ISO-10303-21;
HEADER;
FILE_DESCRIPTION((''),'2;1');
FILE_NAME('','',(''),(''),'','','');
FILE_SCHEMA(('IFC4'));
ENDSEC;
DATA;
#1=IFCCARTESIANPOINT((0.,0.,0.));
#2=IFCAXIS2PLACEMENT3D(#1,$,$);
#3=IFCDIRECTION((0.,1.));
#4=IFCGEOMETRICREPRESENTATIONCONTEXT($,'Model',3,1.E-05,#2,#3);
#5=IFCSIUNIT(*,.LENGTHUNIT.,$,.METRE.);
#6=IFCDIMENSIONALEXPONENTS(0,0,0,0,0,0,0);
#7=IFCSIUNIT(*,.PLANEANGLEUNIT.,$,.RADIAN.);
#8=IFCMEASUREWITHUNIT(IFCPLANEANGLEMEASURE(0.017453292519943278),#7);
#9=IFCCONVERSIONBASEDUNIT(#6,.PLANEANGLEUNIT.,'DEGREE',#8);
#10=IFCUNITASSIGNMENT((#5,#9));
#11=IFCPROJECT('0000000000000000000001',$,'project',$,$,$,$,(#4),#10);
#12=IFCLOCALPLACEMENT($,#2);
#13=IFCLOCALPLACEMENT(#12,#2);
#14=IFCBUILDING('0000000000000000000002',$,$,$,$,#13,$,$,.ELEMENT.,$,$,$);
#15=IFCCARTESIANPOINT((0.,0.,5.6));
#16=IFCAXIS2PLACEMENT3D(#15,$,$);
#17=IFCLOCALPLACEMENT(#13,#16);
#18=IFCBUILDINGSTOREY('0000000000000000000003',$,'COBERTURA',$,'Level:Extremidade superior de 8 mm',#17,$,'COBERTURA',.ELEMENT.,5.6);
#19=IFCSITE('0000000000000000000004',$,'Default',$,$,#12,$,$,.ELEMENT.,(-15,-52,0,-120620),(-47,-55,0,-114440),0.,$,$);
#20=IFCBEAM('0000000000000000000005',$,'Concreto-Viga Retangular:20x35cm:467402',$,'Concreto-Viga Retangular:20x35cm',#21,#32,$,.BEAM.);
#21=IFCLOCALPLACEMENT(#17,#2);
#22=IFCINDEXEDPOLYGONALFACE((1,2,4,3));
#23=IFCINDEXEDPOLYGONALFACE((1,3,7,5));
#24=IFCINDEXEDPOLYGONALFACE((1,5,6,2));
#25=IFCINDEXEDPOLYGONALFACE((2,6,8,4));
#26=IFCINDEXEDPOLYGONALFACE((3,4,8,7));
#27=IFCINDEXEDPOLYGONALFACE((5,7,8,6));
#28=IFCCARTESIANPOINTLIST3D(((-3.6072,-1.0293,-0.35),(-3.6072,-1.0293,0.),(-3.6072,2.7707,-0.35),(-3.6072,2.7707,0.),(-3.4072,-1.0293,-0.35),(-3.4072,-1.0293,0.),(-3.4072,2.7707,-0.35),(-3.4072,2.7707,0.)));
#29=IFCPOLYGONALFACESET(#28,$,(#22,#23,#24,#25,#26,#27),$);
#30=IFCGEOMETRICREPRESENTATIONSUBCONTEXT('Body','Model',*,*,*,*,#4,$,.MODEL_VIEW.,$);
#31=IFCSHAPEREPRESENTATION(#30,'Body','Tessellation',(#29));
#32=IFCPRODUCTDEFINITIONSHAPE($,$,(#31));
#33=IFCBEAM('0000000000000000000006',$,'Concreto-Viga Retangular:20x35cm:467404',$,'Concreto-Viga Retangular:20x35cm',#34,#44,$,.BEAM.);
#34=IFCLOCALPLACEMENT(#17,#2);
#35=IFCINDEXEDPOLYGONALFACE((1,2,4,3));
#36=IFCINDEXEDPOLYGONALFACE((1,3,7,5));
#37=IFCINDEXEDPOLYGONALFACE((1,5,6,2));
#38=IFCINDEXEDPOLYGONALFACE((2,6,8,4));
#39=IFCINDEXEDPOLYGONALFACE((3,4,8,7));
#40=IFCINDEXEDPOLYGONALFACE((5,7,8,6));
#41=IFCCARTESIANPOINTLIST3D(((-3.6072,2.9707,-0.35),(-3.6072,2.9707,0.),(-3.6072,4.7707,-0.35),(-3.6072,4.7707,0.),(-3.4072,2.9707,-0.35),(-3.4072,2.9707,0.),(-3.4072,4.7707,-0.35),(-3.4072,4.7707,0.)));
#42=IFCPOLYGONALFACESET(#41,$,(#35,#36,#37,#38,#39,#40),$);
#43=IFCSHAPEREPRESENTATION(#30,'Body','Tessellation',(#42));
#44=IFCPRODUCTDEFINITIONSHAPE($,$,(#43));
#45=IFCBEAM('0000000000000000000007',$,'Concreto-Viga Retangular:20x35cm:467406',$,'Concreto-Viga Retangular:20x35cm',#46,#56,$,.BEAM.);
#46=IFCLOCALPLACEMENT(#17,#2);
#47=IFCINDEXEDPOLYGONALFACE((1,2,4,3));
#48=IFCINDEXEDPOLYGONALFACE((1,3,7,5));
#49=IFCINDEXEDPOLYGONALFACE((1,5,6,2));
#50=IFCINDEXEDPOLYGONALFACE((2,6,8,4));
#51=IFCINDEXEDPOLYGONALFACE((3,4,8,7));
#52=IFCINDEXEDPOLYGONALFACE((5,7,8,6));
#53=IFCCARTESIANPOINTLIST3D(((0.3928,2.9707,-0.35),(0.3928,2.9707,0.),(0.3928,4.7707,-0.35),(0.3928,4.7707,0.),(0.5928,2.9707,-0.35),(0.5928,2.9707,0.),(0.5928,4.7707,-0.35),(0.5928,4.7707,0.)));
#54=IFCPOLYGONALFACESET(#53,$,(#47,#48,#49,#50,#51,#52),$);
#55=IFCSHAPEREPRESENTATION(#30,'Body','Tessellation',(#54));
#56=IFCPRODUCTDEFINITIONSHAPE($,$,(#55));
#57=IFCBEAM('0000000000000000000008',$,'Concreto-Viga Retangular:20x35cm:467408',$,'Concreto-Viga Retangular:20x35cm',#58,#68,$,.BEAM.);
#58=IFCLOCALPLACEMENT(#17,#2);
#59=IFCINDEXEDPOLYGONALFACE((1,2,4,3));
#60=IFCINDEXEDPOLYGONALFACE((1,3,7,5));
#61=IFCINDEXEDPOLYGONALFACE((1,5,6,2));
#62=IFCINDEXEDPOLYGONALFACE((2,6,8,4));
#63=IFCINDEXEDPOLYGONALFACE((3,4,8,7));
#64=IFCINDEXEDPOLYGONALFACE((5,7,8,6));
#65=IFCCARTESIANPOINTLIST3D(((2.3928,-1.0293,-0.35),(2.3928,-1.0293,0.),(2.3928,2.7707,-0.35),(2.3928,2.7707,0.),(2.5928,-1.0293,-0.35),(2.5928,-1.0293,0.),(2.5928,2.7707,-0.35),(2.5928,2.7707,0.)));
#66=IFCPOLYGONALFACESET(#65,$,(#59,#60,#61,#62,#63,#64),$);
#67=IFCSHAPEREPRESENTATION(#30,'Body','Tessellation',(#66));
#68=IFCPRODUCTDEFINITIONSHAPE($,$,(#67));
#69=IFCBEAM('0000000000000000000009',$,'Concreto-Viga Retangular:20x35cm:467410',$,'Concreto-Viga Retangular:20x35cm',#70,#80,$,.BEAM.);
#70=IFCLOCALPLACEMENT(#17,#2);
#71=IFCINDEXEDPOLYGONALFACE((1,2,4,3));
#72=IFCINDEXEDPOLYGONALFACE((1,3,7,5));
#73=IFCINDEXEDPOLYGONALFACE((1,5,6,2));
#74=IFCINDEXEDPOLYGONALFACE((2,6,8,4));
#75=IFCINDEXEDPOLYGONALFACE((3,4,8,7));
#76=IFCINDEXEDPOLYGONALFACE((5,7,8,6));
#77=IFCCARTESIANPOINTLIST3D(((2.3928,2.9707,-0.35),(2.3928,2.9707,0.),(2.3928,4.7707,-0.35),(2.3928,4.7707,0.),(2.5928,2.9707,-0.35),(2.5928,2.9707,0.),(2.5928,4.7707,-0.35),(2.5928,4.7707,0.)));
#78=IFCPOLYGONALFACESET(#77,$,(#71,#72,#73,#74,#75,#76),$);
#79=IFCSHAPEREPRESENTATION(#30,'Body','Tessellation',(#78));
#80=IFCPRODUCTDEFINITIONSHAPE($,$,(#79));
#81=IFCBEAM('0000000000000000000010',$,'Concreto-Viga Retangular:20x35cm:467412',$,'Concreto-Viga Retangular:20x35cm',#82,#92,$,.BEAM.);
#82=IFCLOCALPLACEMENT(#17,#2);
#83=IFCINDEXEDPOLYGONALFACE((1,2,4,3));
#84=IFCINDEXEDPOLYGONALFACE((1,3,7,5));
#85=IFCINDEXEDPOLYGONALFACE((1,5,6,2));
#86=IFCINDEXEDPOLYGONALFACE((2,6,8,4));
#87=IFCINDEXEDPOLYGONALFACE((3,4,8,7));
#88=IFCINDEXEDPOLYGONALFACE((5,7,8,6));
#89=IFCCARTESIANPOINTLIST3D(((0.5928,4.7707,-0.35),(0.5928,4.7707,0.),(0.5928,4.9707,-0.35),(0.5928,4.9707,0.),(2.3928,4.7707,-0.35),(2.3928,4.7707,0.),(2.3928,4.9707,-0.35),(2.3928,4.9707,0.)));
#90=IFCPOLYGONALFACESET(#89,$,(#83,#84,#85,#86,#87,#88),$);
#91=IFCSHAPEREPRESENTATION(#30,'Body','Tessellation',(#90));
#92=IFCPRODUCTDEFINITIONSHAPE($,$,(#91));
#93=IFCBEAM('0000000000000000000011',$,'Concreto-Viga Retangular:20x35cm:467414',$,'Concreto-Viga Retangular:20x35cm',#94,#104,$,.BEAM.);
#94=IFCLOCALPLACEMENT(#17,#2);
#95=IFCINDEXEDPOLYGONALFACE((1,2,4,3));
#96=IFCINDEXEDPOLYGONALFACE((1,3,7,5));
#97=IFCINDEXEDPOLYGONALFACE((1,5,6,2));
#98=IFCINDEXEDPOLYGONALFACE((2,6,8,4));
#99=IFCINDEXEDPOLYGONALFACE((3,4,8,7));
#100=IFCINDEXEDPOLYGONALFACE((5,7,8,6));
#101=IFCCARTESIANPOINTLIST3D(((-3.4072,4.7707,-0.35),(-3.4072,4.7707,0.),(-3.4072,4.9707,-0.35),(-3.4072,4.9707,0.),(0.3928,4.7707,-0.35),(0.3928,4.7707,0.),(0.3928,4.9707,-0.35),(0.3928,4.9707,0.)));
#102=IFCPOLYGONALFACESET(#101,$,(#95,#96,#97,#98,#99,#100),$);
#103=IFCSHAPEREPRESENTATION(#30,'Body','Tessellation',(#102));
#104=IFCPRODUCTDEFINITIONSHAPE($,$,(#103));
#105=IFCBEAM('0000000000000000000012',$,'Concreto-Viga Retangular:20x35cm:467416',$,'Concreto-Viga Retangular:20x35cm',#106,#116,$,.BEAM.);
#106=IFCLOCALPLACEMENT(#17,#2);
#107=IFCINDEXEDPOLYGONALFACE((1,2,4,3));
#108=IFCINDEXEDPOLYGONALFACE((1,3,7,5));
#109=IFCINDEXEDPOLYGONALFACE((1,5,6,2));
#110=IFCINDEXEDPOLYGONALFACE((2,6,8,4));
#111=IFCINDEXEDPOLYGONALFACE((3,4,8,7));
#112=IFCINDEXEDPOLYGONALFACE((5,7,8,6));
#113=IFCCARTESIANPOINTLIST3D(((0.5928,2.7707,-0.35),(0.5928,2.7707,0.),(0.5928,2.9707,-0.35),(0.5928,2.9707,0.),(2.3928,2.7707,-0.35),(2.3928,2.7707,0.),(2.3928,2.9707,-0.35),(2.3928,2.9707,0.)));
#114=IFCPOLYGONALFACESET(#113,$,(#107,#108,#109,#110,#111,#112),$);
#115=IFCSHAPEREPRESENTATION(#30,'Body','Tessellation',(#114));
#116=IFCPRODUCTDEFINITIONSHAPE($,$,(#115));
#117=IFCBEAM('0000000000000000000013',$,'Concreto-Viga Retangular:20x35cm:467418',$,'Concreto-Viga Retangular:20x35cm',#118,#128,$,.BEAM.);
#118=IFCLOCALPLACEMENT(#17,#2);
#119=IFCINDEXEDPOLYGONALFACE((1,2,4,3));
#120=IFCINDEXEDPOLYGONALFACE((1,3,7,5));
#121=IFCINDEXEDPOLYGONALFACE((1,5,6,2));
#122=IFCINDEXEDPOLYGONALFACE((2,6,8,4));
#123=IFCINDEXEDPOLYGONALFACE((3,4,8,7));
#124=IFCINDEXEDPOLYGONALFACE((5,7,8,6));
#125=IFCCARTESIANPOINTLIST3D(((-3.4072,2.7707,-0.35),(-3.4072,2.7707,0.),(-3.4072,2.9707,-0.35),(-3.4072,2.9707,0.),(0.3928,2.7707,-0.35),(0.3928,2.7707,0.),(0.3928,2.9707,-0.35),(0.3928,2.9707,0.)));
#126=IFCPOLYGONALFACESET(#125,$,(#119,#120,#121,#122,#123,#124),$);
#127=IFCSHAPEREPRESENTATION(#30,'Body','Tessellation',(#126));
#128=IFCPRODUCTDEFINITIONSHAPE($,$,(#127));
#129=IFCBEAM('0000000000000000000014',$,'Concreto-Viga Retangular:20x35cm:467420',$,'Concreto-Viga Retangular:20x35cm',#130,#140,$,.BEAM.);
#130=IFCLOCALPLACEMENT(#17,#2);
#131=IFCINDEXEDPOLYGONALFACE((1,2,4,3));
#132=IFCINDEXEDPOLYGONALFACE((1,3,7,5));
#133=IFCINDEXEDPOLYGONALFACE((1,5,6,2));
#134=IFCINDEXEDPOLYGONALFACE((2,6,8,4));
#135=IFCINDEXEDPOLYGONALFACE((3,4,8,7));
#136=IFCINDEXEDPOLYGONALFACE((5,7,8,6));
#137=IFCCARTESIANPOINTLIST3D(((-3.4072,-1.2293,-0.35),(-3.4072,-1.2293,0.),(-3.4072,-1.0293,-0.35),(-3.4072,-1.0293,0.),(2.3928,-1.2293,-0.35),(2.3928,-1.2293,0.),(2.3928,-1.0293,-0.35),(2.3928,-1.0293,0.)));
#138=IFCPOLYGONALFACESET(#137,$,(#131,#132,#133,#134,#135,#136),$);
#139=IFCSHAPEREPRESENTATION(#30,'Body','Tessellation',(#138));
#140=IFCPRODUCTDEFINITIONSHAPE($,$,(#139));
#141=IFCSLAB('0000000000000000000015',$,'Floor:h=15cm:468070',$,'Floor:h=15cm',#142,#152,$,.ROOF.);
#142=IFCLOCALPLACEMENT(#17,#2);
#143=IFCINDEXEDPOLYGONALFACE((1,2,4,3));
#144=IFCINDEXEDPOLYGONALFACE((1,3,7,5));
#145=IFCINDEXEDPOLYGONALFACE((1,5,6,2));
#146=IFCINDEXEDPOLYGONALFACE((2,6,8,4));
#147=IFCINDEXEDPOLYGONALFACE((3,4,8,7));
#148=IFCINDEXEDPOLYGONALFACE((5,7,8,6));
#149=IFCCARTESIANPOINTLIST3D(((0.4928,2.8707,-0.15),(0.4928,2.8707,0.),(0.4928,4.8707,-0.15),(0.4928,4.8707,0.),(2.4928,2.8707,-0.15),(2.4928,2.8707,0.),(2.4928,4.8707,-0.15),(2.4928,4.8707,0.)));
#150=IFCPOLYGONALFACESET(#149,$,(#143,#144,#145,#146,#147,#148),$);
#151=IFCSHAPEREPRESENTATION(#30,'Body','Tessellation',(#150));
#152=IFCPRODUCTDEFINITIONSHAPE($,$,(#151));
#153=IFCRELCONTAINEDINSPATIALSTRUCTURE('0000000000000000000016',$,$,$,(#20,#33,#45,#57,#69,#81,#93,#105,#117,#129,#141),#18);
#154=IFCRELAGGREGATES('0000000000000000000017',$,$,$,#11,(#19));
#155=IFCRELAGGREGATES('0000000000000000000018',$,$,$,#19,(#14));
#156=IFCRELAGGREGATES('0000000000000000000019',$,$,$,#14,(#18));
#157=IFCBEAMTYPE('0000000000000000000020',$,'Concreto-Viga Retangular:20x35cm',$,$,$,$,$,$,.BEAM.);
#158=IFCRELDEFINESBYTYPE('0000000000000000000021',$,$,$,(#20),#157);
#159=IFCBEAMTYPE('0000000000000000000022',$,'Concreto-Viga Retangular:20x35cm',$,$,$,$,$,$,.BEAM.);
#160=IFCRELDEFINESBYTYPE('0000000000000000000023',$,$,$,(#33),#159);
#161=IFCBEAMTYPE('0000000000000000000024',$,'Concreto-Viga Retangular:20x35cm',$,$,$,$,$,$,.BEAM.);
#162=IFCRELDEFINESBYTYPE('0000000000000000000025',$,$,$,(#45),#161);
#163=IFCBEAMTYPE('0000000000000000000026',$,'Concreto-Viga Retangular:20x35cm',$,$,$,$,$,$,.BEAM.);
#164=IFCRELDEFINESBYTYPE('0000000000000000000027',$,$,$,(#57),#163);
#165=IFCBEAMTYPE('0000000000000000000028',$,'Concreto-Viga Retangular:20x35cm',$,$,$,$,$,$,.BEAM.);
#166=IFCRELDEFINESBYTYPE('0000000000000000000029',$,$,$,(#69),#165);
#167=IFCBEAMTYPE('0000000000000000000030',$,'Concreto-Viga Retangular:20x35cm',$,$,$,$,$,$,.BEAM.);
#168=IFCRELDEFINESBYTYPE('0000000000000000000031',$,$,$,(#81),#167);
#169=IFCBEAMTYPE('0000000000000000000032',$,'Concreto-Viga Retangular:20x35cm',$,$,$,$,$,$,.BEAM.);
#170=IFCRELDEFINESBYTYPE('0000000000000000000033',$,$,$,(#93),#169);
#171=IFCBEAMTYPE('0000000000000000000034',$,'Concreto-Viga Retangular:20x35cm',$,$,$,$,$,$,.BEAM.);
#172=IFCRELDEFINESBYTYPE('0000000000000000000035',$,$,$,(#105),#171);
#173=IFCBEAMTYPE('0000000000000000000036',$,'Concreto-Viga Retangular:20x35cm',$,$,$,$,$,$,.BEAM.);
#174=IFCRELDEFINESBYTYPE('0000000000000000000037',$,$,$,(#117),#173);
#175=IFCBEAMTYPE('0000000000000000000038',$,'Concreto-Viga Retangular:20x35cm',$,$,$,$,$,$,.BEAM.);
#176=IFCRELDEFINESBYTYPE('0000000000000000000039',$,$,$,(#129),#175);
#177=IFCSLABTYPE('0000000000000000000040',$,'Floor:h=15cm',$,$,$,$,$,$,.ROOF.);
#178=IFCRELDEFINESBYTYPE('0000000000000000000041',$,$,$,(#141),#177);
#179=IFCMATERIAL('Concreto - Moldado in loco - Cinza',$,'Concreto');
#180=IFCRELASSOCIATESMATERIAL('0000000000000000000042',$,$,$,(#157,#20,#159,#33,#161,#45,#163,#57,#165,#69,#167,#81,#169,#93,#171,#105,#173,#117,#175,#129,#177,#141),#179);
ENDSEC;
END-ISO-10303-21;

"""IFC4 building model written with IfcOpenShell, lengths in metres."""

from ifc_helpers import new_model, entity, si_unit, converted_unit, direction, frame, origin, place, context, subcontext, project, spatial, indexed_curve, outline, extrude, source, transform, mapped, material, type_object, type_shapes, element, save


model = new_model("IFC4")

# Units and contexts
model_context = context("Model", 3, precision=1e-05, world=origin(), true_north=direction((0.0, 1.0)))
body_context = subcontext(model_context, "Body", "Model", "MODEL_VIEW")
ifc_project = project(units=[si_unit("LENGTHUNIT", "METRE"), converted_unit("PLANEANGLEUNIT", "DEGREE", entity("IfcPlaneAngleMeasure", 0.017453292519943278), si_unit("PLANEANGLEUNIT", "RADIAN"), dimensions=[0, 0, 0, 0, 0, 0, 0])], contexts=[model_context])

# Site, building, storey
site_placement = place(None, origin())
site = spatial("IfcSite", under=ifc_project, at=site_placement, Name="Default", CompositionType="ELEMENT", RefLatitude=(-15, -52, 0, -120620), RefLongitude=(-47, -55, 0, -114440), RefElevation=0.0)
building_placement = place(site_placement, origin())
building = spatial("IfcBuilding", under=site, at=building_placement, CompositionType="ELEMENT")
storey_placement = place(building_placement, frame((0.0, 0.0, 5.6)))
storey = spatial("IfcBuildingStorey", under=building, at=storey_placement, Name="COBERTURA", ObjectType="Level:Extremidade superior de 8 mm", LongName="COBERTURA", CompositionType="ELEMENT", Elevation=5.6)

# Beams
ifc_material = material(Name="Concreto - Moldado in loco - Cinza", Category="Concreto")
beam_type_1 = type_object("IfcBeamType", Name="Concreto-Viga Retangular:20x35cm", PredefinedType="BEAM", material=ifc_material)
shared_shape_1 = source(origin(), body_context, "Body", "SweptSolid", [
    extrude(outline(indexed_curve([(-0.1, -0.175), (0.1, -0.175), (0.1, 0.175), (-0.1, 0.175), (-0.1, -0.175)], self_intersect=False)), frame((-3.5072, -1.0293, 5.425), z_axis=(0.0, 1.0, 0.0), x_axis=(-1.0, 0.0, 0.0)), (0.0, 0.0, 1.0), 3.8),
])
type_shapes(beam_type_1, [shared_shape_1])
beam_1_placement = place(storey_placement, frame((0.0, 0.0, -5.6)))
element("IfcBeam", 1, at=beam_1_placement, inside=storey, type_object=beam_type_1, material=ifc_material, Name="Concreto-Viga Retangular:20x35cm:467402", ObjectType="Concreto-Viga Retangular:20x35cm", PredefinedType="BEAM", context=body_context, shape_type="MappedRepresentation", body=[
    mapped(shared_shape_1, transform((0.0, 0.0, 0.0), scale=1.0)),
])
beam_type_2 = type_object("IfcBeamType", Name="Concreto-Viga Retangular:20x35cm", PredefinedType="BEAM", material=ifc_material)
shared_shape_2 = source(origin(), body_context, "Body", "SweptSolid", [
    extrude(outline(indexed_curve([(-0.1, -0.175), (0.1, -0.175), (0.1, 0.175), (-0.1, 0.175), (-0.1, -0.175)], self_intersect=False)), frame((-3.5072, 2.9707, 5.425), z_axis=(0.0, 1.0, 0.0), x_axis=(-1.0, 0.0, 0.0)), (0.0, 0.0, 1.0), 1.8),
])
type_shapes(beam_type_2, [shared_shape_2])
beam_2_placement = place(storey_placement, frame((0.0, 0.0, -5.6)))
element("IfcBeam", 2, at=beam_2_placement, inside=storey, type_object=beam_type_2, material=ifc_material, Name="Concreto-Viga Retangular:20x35cm:467404", ObjectType="Concreto-Viga Retangular:20x35cm", PredefinedType="BEAM", context=body_context, shape_type="MappedRepresentation", body=[
    mapped(shared_shape_2, transform((0.0, 0.0, 0.0), scale=1.0)),
])
beam_type_3 = type_object("IfcBeamType", Name="Concreto-Viga Retangular:20x35cm", PredefinedType="BEAM", material=ifc_material)
shared_shape_3 = source(origin(), body_context, "Body", "SweptSolid", [
    extrude(outline(indexed_curve([(-0.1, -0.175), (0.1, -0.175), (0.1, 0.175), (-0.1, 0.175), (-0.1, -0.175)], self_intersect=False)), frame((0.4928, 2.9707, 5.425), z_axis=(0.0, 1.0, 0.0), x_axis=(-1.0, 0.0, 0.0)), (0.0, 0.0, 1.0), 1.8),
])
type_shapes(beam_type_3, [shared_shape_3])
beam_3_placement = place(storey_placement, frame((0.0, 0.0, -5.6)))
element("IfcBeam", 3, at=beam_3_placement, inside=storey, type_object=beam_type_3, material=ifc_material, Name="Concreto-Viga Retangular:20x35cm:467406", ObjectType="Concreto-Viga Retangular:20x35cm", PredefinedType="BEAM", context=body_context, shape_type="MappedRepresentation", body=[
    mapped(shared_shape_3, transform((0.0, 0.0, 0.0), scale=1.0)),
])
beam_type_4 = type_object("IfcBeamType", Name="Concreto-Viga Retangular:20x35cm", PredefinedType="BEAM", material=ifc_material)
shared_shape_4 = source(origin(), body_context, "Body", "SweptSolid", [
    extrude(outline(indexed_curve([(-0.1, -0.175), (0.1, -0.175), (0.1, 0.175), (-0.1, 0.175), (-0.1, -0.175)], self_intersect=False)), frame((2.4928, -1.0293, 5.425), z_axis=(0.0, 1.0, 0.0), x_axis=(-1.0, 0.0, 0.0)), (0.0, 0.0, 1.0), 3.8),
])
type_shapes(beam_type_4, [shared_shape_4])
beam_4_placement = place(storey_placement, frame((0.0, 0.0, -5.6)))
element("IfcBeam", 4, at=beam_4_placement, inside=storey, type_object=beam_type_4, material=ifc_material, Name="Concreto-Viga Retangular:20x35cm:467408", ObjectType="Concreto-Viga Retangular:20x35cm", PredefinedType="BEAM", context=body_context, shape_type="MappedRepresentation", body=[
    mapped(shared_shape_4, transform((0.0, 0.0, 0.0), scale=1.0)),
])
beam_type_5 = type_object("IfcBeamType", Name="Concreto-Viga Retangular:20x35cm", PredefinedType="BEAM", material=ifc_material)
shared_shape_5 = source(origin(), body_context, "Body", "SweptSolid", [
    extrude(outline(indexed_curve([(-0.1, -0.175), (0.1, -0.175), (0.1, 0.175), (-0.1, 0.175), (-0.1, -0.175)], self_intersect=False)), frame((2.4928, 2.9707, 5.425), z_axis=(0.0, 1.0, 0.0), x_axis=(-1.0, 0.0, 0.0)), (0.0, 0.0, 1.0), 1.8),
])
type_shapes(beam_type_5, [shared_shape_5])
beam_5_placement = place(storey_placement, frame((0.0, 0.0, -5.6)))
element("IfcBeam", 5, at=beam_5_placement, inside=storey, type_object=beam_type_5, material=ifc_material, Name="Concreto-Viga Retangular:20x35cm:467410", ObjectType="Concreto-Viga Retangular:20x35cm", PredefinedType="BEAM", context=body_context, shape_type="MappedRepresentation", body=[
    mapped(shared_shape_5, transform((0.0, 0.0, 0.0), scale=1.0)),
])
beam_type_6 = type_object("IfcBeamType", Name="Concreto-Viga Retangular:20x35cm", PredefinedType="BEAM", material=ifc_material)
shared_shape_6 = source(origin(), body_context, "Body", "SweptSolid", [
    extrude(outline(indexed_curve([(-0.175, -0.1), (0.175, -0.1), (0.175, 0.1), (-0.175, 0.1), (-0.175, -0.1)], self_intersect=False)), frame((2.3928, 4.8707, 5.425), z_axis=(-1.0, 0.0, 0.0), x_axis=(0.0, 0.0, -1.0)), (0.0, 0.0, 1.0), 1.8),
])
type_shapes(beam_type_6, [shared_shape_6])
beam_6_placement = place(storey_placement, frame((0.0, 0.0, -5.6)))
element("IfcBeam", 6, at=beam_6_placement, inside=storey, type_object=beam_type_6, material=ifc_material, Name="Concreto-Viga Retangular:20x35cm:467412", ObjectType="Concreto-Viga Retangular:20x35cm", PredefinedType="BEAM", context=body_context, shape_type="MappedRepresentation", body=[
    mapped(shared_shape_6, transform((0.0, 0.0, 0.0), scale=1.0)),
])
beam_type_7 = type_object("IfcBeamType", Name="Concreto-Viga Retangular:20x35cm", PredefinedType="BEAM", material=ifc_material)
shared_shape_7 = source(origin(), body_context, "Body", "SweptSolid", [
    extrude(outline(indexed_curve([(-0.175, -0.1), (0.175, -0.1), (0.175, 0.1), (-0.175, 0.1), (-0.175, -0.1)], self_intersect=False)), frame((0.3928, 4.8707, 5.425), z_axis=(-1.0, 0.0, 0.0), x_axis=(0.0, 0.0, -1.0)), (0.0, 0.0, 1.0), 3.8),
])
type_shapes(beam_type_7, [shared_shape_7])
beam_7_placement = place(storey_placement, frame((0.0, 0.0, -5.6)))
element("IfcBeam", 7, at=beam_7_placement, inside=storey, type_object=beam_type_7, material=ifc_material, Name="Concreto-Viga Retangular:20x35cm:467414", ObjectType="Concreto-Viga Retangular:20x35cm", PredefinedType="BEAM", context=body_context, shape_type="MappedRepresentation", body=[
    mapped(shared_shape_7, transform((0.0, 0.0, 0.0), scale=1.0)),
])
beam_type_8 = type_object("IfcBeamType", Name="Concreto-Viga Retangular:20x35cm", PredefinedType="BEAM", material=ifc_material)
shared_shape_8 = source(origin(), body_context, "Body", "SweptSolid", [
    extrude(outline(indexed_curve([(-0.175, -0.1), (0.175, -0.1), (0.175, 0.1), (-0.175, 0.1), (-0.175, -0.1)], self_intersect=False)), frame((2.3928, 2.8707, 5.425), z_axis=(-1.0, 0.0, 0.0), x_axis=(0.0, 0.0, -1.0)), (0.0, 0.0, 1.0), 1.8),
])
type_shapes(beam_type_8, [shared_shape_8])
beam_8_placement = place(storey_placement, frame((0.0, 0.0, -5.6)))
element("IfcBeam", 8, at=beam_8_placement, inside=storey, type_object=beam_type_8, material=ifc_material, Name="Concreto-Viga Retangular:20x35cm:467416", ObjectType="Concreto-Viga Retangular:20x35cm", PredefinedType="BEAM", context=body_context, shape_type="MappedRepresentation", body=[
    mapped(shared_shape_8, transform((0.0, 0.0, 0.0), scale=1.0)),
])
beam_type_9 = type_object("IfcBeamType", Name="Concreto-Viga Retangular:20x35cm", PredefinedType="BEAM", material=ifc_material)
shared_shape_9 = source(origin(), body_context, "Body", "SweptSolid", [
    extrude(outline(indexed_curve([(-0.175, -0.1), (0.175, -0.1), (0.175, 0.1), (-0.175, 0.1), (-0.175, -0.1)], self_intersect=False)), frame((0.3928, 2.8707, 5.425), z_axis=(-1.0, 0.0, 0.0), x_axis=(0.0, 0.0, -1.0)), (0.0, 0.0, 1.0), 3.8),
])
type_shapes(beam_type_9, [shared_shape_9])
beam_9_placement = place(storey_placement, frame((0.0, 0.0, -5.6)))
element("IfcBeam", 9, at=beam_9_placement, inside=storey, type_object=beam_type_9, material=ifc_material, Name="Concreto-Viga Retangular:20x35cm:467418", ObjectType="Concreto-Viga Retangular:20x35cm", PredefinedType="BEAM", context=body_context, shape_type="MappedRepresentation", body=[
    mapped(shared_shape_9, transform((0.0, 0.0, 0.0), scale=1.0)),
])
beam_type_10 = type_object("IfcBeamType", Name="Concreto-Viga Retangular:20x35cm", PredefinedType="BEAM", material=ifc_material)
shared_shape_10 = source(origin(), body_context, "Body", "SweptSolid", [
    extrude(outline(indexed_curve([(-0.175, -0.1), (0.175, -0.1), (0.175, 0.1), (-0.175, 0.1), (-0.175, -0.1)], self_intersect=False)), frame((2.3928, -1.1293, 5.425), z_axis=(-1.0, 0.0, 0.0), x_axis=(0.0, 0.0, -1.0)), (0.0, 0.0, 1.0), 5.8),
])
type_shapes(beam_type_10, [shared_shape_10])
beam_10_placement = place(storey_placement, frame((0.0, 0.0, -5.6)))
element("IfcBeam", 10, at=beam_10_placement, inside=storey, type_object=beam_type_10, material=ifc_material, Name="Concreto-Viga Retangular:20x35cm:467420", ObjectType="Concreto-Viga Retangular:20x35cm", PredefinedType="BEAM", context=body_context, shape_type="MappedRepresentation", body=[
    mapped(shared_shape_10, transform((0.0, 0.0, 0.0), scale=1.0)),
])

# Slab
slab_type = type_object("IfcSlabType", Name="Floor:h=15cm", PredefinedType="ROOF", material=ifc_material)
slab_1_placement = place(storey_placement, origin())
element("IfcSlab", 11, at=slab_1_placement, inside=storey, type_object=slab_type, material=ifc_material, Name="Floor:h=15cm:468070", ObjectType="Floor:h=15cm", PredefinedType="ROOF", context=body_context, shape_type="SweptSolid", body=[
    extrude(outline(indexed_curve([(-1.0, -1.0), (1.0, -1.0), (1.0, 1.0), (-1.0, 1.0), (-1.0, -1.0)], self_intersect=False)), frame((1.4928, 3.8707, 0.0), z_axis=(0.0, 0.0, -1.0), x_axis=(0.0, 1.0, 0.0)), (0.0, 0.0, 1.0), 0.15),
])

save(model, "model.ifc")
